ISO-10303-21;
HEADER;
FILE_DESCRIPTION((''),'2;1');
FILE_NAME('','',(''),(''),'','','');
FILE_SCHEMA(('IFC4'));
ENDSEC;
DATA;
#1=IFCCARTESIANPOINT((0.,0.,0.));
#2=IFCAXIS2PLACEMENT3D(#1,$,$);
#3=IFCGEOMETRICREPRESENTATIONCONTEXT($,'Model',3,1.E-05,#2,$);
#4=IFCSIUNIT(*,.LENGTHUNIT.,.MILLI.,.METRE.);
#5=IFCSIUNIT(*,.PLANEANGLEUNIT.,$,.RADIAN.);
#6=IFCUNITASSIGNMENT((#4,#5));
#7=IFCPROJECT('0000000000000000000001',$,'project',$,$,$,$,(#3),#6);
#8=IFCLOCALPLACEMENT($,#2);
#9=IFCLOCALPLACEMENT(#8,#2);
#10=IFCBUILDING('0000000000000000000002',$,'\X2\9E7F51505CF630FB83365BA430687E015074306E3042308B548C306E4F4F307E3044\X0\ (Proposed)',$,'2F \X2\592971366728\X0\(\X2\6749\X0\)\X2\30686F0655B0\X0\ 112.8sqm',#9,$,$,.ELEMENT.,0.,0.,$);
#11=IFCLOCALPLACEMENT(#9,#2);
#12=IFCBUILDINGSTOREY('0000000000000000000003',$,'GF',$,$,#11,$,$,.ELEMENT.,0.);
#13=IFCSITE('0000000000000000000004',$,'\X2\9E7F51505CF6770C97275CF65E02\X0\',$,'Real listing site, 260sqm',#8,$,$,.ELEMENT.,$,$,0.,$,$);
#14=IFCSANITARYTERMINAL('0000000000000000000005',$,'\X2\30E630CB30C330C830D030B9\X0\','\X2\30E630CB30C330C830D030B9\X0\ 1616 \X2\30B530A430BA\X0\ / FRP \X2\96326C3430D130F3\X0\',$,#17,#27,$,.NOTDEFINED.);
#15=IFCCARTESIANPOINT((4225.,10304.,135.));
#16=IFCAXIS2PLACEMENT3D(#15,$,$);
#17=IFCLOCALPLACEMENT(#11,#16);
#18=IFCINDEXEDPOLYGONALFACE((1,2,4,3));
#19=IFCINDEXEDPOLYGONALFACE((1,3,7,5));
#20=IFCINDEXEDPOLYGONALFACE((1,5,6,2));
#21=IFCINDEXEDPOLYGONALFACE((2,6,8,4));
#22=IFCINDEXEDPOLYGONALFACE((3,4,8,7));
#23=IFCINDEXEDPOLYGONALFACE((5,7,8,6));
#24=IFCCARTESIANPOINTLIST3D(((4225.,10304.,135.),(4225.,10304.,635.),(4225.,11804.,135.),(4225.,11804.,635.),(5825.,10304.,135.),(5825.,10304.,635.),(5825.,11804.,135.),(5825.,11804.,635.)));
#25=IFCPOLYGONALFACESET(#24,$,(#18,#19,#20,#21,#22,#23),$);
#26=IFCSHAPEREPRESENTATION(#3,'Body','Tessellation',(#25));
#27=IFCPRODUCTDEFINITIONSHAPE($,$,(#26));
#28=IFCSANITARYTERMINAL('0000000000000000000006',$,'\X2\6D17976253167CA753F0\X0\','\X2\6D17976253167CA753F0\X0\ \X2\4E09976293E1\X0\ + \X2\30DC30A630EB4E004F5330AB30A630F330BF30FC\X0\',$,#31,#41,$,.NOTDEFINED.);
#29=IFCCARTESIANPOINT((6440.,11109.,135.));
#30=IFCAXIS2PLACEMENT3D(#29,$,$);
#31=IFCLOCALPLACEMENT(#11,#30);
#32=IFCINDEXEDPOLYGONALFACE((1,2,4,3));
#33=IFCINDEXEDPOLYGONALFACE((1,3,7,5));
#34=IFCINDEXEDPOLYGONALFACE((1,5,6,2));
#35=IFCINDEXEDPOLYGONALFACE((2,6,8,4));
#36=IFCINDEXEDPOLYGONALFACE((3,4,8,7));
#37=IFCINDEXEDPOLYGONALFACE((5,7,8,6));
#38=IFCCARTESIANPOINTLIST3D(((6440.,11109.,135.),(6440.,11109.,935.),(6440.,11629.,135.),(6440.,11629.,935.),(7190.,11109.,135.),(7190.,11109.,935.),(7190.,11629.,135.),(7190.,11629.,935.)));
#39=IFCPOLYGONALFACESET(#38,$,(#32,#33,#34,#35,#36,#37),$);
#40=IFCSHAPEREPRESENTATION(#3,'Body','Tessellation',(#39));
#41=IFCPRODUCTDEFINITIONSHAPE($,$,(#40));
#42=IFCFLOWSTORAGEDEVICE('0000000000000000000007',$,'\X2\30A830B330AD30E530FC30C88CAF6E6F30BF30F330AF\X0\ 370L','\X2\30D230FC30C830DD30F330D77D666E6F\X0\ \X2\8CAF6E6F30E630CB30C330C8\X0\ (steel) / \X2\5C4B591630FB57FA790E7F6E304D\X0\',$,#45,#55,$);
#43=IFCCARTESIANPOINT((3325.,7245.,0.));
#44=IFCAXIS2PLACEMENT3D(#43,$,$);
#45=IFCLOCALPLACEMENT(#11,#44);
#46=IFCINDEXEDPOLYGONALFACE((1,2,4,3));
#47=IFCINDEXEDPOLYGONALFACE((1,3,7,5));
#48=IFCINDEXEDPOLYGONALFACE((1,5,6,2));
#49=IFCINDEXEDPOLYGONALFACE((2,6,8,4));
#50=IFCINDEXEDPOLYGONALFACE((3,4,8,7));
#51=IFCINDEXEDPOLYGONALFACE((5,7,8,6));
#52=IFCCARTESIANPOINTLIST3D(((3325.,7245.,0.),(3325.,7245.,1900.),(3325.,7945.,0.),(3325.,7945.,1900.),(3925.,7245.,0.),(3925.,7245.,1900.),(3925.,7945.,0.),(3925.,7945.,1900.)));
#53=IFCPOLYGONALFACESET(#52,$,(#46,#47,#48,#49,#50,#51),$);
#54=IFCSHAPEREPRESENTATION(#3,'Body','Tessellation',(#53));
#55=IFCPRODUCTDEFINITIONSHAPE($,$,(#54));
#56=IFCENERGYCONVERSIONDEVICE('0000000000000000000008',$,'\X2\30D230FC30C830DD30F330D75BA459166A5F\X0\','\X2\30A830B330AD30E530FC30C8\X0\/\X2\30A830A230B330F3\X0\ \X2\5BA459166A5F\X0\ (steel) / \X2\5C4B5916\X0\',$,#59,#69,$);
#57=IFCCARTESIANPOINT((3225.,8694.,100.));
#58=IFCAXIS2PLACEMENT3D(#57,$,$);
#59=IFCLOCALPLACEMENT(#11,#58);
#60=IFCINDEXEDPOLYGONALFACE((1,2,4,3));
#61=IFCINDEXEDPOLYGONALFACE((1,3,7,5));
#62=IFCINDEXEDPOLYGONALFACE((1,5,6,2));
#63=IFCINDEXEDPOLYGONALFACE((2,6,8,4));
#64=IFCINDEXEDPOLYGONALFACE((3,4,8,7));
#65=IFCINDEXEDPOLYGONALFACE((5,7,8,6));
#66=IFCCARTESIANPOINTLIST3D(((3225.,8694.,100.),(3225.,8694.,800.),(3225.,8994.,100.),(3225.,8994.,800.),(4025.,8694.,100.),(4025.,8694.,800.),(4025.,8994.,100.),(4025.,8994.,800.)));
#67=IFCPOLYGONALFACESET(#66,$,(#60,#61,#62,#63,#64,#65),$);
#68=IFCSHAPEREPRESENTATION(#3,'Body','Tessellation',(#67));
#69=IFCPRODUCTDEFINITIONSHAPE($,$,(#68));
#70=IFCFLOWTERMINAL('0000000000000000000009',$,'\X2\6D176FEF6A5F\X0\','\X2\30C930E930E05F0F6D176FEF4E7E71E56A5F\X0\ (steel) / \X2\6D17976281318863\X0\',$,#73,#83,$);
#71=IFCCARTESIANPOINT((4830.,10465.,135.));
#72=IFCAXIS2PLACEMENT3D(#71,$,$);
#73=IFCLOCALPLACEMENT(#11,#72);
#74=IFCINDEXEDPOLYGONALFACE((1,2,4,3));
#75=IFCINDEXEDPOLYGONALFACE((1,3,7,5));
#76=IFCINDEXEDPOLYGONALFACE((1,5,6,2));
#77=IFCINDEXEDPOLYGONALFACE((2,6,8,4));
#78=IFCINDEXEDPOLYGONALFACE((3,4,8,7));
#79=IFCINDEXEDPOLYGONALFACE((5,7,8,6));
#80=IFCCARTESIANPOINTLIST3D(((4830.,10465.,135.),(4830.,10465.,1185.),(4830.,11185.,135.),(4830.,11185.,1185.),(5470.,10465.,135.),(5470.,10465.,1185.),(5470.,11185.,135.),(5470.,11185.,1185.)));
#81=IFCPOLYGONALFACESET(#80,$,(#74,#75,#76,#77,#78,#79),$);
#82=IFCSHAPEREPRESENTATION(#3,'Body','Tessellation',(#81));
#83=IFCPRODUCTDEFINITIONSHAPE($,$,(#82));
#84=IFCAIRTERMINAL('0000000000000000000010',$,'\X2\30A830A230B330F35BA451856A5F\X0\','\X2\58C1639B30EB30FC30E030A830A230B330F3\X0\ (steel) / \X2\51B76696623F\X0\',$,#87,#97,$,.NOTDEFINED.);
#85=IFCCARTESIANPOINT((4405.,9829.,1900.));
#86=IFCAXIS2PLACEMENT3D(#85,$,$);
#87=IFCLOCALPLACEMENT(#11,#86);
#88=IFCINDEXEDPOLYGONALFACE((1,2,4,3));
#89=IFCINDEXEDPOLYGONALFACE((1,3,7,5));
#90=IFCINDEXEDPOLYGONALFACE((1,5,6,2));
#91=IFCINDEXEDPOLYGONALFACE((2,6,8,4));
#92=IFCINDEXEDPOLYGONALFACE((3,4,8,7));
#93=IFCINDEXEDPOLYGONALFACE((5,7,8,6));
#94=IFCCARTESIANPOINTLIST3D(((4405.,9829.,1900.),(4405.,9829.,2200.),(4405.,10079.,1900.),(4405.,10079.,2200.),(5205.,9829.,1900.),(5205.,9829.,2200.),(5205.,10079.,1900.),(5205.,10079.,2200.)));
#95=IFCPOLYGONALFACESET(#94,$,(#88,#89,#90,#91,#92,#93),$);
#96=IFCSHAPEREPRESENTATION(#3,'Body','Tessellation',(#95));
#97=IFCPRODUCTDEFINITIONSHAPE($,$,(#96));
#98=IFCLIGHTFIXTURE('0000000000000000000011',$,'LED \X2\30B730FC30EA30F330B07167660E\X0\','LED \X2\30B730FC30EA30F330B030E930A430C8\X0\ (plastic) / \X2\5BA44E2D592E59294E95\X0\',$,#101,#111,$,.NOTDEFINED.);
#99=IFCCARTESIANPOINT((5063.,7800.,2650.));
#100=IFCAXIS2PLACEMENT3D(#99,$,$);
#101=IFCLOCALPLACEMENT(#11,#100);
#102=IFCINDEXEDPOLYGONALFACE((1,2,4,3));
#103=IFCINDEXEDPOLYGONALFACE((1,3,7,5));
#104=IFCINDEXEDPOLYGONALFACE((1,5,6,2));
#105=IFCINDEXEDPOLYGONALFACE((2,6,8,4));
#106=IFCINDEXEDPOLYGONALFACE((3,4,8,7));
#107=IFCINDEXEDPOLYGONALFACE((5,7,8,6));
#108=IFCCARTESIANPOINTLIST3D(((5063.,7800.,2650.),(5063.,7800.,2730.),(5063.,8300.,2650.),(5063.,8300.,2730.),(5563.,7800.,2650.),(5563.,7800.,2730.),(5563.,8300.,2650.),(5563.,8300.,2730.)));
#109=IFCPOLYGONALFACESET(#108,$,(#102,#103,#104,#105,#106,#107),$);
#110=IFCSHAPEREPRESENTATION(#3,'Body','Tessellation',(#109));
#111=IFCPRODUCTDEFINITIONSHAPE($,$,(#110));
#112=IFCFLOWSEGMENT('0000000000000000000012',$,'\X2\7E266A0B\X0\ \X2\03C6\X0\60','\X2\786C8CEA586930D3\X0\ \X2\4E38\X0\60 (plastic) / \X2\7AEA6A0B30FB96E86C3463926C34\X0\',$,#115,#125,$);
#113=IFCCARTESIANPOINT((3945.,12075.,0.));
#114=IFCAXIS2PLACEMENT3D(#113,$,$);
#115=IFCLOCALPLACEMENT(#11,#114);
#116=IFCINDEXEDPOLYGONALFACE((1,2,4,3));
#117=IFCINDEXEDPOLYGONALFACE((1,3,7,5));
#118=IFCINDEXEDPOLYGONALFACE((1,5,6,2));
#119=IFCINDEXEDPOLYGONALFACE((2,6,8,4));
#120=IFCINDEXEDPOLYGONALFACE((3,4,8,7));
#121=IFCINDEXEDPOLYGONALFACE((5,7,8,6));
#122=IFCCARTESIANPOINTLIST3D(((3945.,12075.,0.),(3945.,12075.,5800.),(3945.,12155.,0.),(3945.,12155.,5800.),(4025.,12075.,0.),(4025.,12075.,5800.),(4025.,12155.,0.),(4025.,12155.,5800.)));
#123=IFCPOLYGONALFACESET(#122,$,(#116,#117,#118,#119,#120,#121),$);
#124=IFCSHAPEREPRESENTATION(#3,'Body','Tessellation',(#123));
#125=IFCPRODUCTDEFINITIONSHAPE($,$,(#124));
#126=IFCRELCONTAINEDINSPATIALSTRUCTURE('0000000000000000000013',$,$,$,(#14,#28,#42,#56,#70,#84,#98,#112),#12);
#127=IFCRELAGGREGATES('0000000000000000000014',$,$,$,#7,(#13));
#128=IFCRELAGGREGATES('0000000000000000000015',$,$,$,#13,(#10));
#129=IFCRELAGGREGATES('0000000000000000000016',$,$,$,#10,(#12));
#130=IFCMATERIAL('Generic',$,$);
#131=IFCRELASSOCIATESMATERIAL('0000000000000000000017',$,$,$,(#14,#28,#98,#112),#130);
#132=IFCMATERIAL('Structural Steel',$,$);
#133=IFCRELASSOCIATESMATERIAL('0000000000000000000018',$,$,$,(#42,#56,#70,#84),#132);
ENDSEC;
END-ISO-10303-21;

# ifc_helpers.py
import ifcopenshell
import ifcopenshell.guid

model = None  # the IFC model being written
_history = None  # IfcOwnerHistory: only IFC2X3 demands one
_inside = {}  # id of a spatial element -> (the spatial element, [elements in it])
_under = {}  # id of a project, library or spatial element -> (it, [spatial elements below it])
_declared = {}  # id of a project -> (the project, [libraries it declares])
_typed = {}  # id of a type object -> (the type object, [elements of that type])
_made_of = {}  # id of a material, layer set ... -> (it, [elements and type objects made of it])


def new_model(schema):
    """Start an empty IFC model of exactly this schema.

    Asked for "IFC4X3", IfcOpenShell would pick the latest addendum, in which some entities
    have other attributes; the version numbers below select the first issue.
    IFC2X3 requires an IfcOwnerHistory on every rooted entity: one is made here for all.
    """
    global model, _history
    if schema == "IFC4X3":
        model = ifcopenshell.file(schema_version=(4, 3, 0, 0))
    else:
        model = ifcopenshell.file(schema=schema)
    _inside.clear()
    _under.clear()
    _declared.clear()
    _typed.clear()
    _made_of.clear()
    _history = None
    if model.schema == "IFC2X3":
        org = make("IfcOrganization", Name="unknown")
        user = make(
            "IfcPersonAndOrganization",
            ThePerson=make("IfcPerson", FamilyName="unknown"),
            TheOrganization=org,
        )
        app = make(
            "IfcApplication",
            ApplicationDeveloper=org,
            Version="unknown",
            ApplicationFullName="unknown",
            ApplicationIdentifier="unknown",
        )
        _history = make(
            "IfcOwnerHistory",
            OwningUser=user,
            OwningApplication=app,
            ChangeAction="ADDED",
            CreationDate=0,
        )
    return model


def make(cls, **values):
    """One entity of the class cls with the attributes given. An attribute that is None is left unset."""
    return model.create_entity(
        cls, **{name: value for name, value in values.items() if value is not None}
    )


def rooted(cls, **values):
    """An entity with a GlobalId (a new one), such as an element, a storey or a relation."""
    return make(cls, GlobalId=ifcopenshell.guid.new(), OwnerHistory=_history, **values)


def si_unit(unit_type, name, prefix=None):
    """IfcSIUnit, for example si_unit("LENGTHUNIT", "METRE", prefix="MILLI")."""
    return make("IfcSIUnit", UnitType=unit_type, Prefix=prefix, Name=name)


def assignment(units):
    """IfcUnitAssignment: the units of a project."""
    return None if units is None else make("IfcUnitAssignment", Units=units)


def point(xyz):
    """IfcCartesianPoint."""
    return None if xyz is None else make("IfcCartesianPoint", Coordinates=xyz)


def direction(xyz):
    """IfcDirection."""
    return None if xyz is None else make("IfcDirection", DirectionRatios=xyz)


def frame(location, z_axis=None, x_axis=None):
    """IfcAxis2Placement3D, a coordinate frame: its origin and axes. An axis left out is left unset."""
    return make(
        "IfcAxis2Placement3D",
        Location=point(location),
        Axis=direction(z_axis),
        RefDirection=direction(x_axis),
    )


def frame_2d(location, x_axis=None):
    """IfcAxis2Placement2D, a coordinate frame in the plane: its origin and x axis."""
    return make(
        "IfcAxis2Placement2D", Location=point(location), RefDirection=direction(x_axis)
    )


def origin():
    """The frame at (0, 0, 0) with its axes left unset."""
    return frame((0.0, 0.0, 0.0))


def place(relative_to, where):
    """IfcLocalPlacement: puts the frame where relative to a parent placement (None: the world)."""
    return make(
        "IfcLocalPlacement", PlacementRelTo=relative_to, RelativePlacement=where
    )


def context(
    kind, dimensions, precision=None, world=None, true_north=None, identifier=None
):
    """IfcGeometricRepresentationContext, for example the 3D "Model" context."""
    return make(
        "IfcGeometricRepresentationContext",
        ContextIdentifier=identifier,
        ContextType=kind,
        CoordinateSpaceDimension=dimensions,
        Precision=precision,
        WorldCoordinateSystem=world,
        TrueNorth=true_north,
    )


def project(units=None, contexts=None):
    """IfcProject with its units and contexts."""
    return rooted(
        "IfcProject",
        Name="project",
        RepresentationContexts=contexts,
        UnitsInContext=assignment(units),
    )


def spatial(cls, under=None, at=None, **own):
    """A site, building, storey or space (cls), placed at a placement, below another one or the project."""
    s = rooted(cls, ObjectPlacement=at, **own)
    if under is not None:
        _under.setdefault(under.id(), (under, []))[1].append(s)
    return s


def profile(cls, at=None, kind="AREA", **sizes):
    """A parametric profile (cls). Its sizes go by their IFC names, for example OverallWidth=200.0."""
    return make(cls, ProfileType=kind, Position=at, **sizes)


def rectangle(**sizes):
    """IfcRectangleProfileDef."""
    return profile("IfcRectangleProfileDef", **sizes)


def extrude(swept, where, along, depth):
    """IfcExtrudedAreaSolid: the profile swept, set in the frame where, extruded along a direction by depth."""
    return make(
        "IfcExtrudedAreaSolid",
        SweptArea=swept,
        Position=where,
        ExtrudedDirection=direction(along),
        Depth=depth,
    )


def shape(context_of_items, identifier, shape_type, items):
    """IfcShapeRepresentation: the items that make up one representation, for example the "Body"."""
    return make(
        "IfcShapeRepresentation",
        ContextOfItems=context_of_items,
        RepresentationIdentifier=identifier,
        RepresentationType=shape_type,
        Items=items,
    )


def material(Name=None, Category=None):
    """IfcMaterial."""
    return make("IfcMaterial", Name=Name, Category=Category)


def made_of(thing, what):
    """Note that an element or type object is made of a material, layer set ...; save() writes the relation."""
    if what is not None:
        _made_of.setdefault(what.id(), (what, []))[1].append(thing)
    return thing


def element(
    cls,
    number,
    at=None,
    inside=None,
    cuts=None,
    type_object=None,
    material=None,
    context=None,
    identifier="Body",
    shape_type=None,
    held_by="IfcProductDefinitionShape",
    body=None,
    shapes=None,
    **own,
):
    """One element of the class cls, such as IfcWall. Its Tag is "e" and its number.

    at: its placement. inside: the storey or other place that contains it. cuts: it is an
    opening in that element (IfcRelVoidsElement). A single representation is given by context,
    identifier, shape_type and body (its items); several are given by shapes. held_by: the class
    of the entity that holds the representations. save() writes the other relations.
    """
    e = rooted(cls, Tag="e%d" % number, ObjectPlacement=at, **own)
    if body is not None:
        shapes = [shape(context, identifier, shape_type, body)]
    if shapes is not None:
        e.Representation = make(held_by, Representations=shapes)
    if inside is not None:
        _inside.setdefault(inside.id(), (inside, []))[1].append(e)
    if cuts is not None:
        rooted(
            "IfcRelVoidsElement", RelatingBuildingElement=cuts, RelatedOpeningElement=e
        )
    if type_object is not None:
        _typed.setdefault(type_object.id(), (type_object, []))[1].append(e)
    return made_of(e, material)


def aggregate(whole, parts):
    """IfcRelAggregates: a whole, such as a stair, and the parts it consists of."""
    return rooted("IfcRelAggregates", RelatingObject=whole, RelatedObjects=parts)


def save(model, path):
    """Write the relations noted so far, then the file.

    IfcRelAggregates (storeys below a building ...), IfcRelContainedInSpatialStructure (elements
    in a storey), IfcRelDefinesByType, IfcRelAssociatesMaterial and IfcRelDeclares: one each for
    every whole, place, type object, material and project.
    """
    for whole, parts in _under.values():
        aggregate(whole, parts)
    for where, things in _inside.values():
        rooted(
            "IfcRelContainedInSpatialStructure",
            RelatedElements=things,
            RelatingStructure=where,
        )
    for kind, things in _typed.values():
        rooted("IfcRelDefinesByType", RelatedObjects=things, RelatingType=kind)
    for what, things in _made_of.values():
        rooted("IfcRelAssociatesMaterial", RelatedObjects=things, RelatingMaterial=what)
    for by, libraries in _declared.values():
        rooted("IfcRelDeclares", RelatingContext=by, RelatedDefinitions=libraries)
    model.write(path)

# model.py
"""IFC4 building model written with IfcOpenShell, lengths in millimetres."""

from ifc_helpers import new_model, si_unit, frame, frame_2d, origin, place, context, project, spatial, rectangle, extrude, material, element, save


model = new_model("IFC4")

# Units and contexts
model_context = context("Model", 3, precision=1e-05, world=origin())
ifc_project = project(units=[si_unit("LENGTHUNIT", "METRE", prefix="MILLI"), si_unit("PLANEANGLEUNIT", "RADIAN")], contexts=[model_context])

# Site, building, storey
site_placement = place(None, origin())
site = spatial("IfcSite", under=ifc_project, at=site_placement, Name="鹿児島県霧島市", ObjectType="Real listing site, 260sqm", CompositionType="ELEMENT", RefElevation=0.0)
building_placement = place(site_placement, origin())
building = spatial("IfcBuilding", under=site, at=building_placement, Name="鹿児島・茶室と縁側のある和の住まい (Proposed)", ObjectType="2F 天然木(杉)と漆喰 112.8sqm", CompositionType="ELEMENT", ElevationOfRefHeight=0.0, ElevationOfTerrain=0.0)
storey_placement = place(building_placement, origin())
storey = spatial("IfcBuildingStorey", under=building, at=storey_placement, Name="GF", CompositionType="ELEMENT", Elevation=0.0)

# Shared definitions
ifc_material_1 = material(Name="Generic")

# Sanitary terminals
sanitary_terminal_1_placement = place(storey_placement, frame((4225.0, 10304.0, 135.0)))
element("IfcSanitaryTerminal", 1, at=sanitary_terminal_1_placement, inside=storey, material=ifc_material_1, Name="ユニットバス", Description="ユニットバス 1616 サイズ / FRP 防水パン", PredefinedType="NOTDEFINED", context=model_context, shape_type="SweptSolid", body=[
    extrude(rectangle(XDim=1600.0, YDim=1500.0, at=frame_2d((800.0, 750.0))), frame((4225.0, 10304.0, 135.0)), (0.0, 0.0, 1.0), 500.0),
])
sanitary_terminal_2_placement = place(storey_placement, frame((6440.0, 11109.0, 135.0)))
element("IfcSanitaryTerminal", 2, at=sanitary_terminal_2_placement, inside=storey, material=ifc_material_1, Name="洗面化粧台", Description="洗面化粧台 三面鏡 + ボウル一体カウンター", PredefinedType="NOTDEFINED", context=model_context, shape_type="SweptSolid", body=[
    extrude(rectangle(XDim=750.0, YDim=520.0, at=frame_2d((375.0, 260.0))), frame((6440.0, 11109.0, 135.0)), (0.0, 0.0, 1.0), 800.0),
])

# Flow storage device
ifc_material_2 = material(Name="Structural Steel")
flow_storage_device_placement = place(storey_placement, frame((3325.0, 7245.0, 0.0)))
element("IfcFlowStorageDevice", 3, at=flow_storage_device_placement, inside=storey, material=ifc_material_2, Name="エコキュート貯湯タンク 370L", Description="ヒートポンプ給湯 貯湯ユニット (steel) / 屋外・基礎置き", context=model_context, shape_type="SweptSolid", body=[
    extrude(rectangle(XDim=600.0, YDim=700.0, at=frame_2d((300.0, 350.0))), frame((3325.0, 7245.0, 0.0)), (0.0, 0.0, 1.0), 1900.0),
])

# Energy conversion device
energy_conversion_device_placement = place(storey_placement, frame((3225.0, 8694.0, 100.0)))
element("IfcEnergyConversionDevice", 4, at=energy_conversion_device_placement, inside=storey, material=ifc_material_2, Name="ヒートポンプ室外機", Description="エコキュート/エアコン 室外機 (steel) / 屋外", context=model_context, shape_type="SweptSolid", body=[
    extrude(rectangle(XDim=800.0, YDim=300.0, at=frame_2d((400.0, 150.0))), frame((3225.0, 8694.0, 100.0)), (0.0, 0.0, 1.0), 700.0),
])

# Flow terminal
flow_terminal_placement = place(storey_placement, frame((4830.0, 10465.0, 135.0)))
element("IfcFlowTerminal", 5, at=flow_terminal_placement, inside=storey, material=ifc_material_2, Name="洗濯機", Description="ドラム式洗濯乾燥機 (steel) / 洗面脱衣", context=model_context, shape_type="SweptSolid", body=[
    extrude(rectangle(XDim=640.0, YDim=720.0, at=frame_2d((320.0, 360.0))), frame((4830.0, 10465.0, 135.0)), (0.0, 0.0, 1.0), 1050.0),
])

# Air terminal
air_terminal_placement = place(storey_placement, frame((4405.0, 9829.0, 1900.0)))
element("IfcAirTerminal", 6, at=air_terminal_placement, inside=storey, material=ifc_material_2, Name="エアコン室内機", Description="壁掛ルームエアコン (steel) / 冷暖房", PredefinedType="NOTDEFINED", context=model_context, shape_type="SweptSolid", body=[
    extrude(rectangle(XDim=800.0, YDim=250.0, at=frame_2d((400.0, 125.0))), frame((4405.0, 9829.0, 1900.0)), (0.0, 0.0, 1.0), 300.0),
])

# Light fixture
light_fixture_placement = place(storey_placement, frame((5063.0, 7800.0, 2650.0)))
element("IfcLightFixture", 7, at=light_fixture_placement, inside=storey, material=ifc_material_1, Name="LED シーリング照明", Description="LED シーリングライト (plastic) / 室中央天井", PredefinedType="NOTDEFINED", context=model_context, shape_type="SweptSolid", body=[
    extrude(rectangle(XDim=500.0, YDim=500.0, at=frame_2d((250.0, 250.0))), frame((5063.0, 7800.0, 2650.0)), (0.0, 0.0, 1.0), 80.0),
])

# Flow segment
flow_segment_placement = place(storey_placement, frame((3945.0, 12075.0, 0.0)))
element("IfcFlowSegment", 8, at=flow_segment_placement, inside=storey, material=ifc_material_1, Name="縦樋 φ60", Description="硬質塩ビ 丸60 (plastic) / 竪樋・雨水排水", context=model_context, shape_type="SweptSolid", body=[
    extrude(rectangle(XDim=80.0, YDim=80.0, at=frame_2d((40.0, 40.0))), frame((3945.0, 12075.0, 0.0)), (0.0, 0.0, 1.0), 5800.0),
])

save(model, "model.ifc")
